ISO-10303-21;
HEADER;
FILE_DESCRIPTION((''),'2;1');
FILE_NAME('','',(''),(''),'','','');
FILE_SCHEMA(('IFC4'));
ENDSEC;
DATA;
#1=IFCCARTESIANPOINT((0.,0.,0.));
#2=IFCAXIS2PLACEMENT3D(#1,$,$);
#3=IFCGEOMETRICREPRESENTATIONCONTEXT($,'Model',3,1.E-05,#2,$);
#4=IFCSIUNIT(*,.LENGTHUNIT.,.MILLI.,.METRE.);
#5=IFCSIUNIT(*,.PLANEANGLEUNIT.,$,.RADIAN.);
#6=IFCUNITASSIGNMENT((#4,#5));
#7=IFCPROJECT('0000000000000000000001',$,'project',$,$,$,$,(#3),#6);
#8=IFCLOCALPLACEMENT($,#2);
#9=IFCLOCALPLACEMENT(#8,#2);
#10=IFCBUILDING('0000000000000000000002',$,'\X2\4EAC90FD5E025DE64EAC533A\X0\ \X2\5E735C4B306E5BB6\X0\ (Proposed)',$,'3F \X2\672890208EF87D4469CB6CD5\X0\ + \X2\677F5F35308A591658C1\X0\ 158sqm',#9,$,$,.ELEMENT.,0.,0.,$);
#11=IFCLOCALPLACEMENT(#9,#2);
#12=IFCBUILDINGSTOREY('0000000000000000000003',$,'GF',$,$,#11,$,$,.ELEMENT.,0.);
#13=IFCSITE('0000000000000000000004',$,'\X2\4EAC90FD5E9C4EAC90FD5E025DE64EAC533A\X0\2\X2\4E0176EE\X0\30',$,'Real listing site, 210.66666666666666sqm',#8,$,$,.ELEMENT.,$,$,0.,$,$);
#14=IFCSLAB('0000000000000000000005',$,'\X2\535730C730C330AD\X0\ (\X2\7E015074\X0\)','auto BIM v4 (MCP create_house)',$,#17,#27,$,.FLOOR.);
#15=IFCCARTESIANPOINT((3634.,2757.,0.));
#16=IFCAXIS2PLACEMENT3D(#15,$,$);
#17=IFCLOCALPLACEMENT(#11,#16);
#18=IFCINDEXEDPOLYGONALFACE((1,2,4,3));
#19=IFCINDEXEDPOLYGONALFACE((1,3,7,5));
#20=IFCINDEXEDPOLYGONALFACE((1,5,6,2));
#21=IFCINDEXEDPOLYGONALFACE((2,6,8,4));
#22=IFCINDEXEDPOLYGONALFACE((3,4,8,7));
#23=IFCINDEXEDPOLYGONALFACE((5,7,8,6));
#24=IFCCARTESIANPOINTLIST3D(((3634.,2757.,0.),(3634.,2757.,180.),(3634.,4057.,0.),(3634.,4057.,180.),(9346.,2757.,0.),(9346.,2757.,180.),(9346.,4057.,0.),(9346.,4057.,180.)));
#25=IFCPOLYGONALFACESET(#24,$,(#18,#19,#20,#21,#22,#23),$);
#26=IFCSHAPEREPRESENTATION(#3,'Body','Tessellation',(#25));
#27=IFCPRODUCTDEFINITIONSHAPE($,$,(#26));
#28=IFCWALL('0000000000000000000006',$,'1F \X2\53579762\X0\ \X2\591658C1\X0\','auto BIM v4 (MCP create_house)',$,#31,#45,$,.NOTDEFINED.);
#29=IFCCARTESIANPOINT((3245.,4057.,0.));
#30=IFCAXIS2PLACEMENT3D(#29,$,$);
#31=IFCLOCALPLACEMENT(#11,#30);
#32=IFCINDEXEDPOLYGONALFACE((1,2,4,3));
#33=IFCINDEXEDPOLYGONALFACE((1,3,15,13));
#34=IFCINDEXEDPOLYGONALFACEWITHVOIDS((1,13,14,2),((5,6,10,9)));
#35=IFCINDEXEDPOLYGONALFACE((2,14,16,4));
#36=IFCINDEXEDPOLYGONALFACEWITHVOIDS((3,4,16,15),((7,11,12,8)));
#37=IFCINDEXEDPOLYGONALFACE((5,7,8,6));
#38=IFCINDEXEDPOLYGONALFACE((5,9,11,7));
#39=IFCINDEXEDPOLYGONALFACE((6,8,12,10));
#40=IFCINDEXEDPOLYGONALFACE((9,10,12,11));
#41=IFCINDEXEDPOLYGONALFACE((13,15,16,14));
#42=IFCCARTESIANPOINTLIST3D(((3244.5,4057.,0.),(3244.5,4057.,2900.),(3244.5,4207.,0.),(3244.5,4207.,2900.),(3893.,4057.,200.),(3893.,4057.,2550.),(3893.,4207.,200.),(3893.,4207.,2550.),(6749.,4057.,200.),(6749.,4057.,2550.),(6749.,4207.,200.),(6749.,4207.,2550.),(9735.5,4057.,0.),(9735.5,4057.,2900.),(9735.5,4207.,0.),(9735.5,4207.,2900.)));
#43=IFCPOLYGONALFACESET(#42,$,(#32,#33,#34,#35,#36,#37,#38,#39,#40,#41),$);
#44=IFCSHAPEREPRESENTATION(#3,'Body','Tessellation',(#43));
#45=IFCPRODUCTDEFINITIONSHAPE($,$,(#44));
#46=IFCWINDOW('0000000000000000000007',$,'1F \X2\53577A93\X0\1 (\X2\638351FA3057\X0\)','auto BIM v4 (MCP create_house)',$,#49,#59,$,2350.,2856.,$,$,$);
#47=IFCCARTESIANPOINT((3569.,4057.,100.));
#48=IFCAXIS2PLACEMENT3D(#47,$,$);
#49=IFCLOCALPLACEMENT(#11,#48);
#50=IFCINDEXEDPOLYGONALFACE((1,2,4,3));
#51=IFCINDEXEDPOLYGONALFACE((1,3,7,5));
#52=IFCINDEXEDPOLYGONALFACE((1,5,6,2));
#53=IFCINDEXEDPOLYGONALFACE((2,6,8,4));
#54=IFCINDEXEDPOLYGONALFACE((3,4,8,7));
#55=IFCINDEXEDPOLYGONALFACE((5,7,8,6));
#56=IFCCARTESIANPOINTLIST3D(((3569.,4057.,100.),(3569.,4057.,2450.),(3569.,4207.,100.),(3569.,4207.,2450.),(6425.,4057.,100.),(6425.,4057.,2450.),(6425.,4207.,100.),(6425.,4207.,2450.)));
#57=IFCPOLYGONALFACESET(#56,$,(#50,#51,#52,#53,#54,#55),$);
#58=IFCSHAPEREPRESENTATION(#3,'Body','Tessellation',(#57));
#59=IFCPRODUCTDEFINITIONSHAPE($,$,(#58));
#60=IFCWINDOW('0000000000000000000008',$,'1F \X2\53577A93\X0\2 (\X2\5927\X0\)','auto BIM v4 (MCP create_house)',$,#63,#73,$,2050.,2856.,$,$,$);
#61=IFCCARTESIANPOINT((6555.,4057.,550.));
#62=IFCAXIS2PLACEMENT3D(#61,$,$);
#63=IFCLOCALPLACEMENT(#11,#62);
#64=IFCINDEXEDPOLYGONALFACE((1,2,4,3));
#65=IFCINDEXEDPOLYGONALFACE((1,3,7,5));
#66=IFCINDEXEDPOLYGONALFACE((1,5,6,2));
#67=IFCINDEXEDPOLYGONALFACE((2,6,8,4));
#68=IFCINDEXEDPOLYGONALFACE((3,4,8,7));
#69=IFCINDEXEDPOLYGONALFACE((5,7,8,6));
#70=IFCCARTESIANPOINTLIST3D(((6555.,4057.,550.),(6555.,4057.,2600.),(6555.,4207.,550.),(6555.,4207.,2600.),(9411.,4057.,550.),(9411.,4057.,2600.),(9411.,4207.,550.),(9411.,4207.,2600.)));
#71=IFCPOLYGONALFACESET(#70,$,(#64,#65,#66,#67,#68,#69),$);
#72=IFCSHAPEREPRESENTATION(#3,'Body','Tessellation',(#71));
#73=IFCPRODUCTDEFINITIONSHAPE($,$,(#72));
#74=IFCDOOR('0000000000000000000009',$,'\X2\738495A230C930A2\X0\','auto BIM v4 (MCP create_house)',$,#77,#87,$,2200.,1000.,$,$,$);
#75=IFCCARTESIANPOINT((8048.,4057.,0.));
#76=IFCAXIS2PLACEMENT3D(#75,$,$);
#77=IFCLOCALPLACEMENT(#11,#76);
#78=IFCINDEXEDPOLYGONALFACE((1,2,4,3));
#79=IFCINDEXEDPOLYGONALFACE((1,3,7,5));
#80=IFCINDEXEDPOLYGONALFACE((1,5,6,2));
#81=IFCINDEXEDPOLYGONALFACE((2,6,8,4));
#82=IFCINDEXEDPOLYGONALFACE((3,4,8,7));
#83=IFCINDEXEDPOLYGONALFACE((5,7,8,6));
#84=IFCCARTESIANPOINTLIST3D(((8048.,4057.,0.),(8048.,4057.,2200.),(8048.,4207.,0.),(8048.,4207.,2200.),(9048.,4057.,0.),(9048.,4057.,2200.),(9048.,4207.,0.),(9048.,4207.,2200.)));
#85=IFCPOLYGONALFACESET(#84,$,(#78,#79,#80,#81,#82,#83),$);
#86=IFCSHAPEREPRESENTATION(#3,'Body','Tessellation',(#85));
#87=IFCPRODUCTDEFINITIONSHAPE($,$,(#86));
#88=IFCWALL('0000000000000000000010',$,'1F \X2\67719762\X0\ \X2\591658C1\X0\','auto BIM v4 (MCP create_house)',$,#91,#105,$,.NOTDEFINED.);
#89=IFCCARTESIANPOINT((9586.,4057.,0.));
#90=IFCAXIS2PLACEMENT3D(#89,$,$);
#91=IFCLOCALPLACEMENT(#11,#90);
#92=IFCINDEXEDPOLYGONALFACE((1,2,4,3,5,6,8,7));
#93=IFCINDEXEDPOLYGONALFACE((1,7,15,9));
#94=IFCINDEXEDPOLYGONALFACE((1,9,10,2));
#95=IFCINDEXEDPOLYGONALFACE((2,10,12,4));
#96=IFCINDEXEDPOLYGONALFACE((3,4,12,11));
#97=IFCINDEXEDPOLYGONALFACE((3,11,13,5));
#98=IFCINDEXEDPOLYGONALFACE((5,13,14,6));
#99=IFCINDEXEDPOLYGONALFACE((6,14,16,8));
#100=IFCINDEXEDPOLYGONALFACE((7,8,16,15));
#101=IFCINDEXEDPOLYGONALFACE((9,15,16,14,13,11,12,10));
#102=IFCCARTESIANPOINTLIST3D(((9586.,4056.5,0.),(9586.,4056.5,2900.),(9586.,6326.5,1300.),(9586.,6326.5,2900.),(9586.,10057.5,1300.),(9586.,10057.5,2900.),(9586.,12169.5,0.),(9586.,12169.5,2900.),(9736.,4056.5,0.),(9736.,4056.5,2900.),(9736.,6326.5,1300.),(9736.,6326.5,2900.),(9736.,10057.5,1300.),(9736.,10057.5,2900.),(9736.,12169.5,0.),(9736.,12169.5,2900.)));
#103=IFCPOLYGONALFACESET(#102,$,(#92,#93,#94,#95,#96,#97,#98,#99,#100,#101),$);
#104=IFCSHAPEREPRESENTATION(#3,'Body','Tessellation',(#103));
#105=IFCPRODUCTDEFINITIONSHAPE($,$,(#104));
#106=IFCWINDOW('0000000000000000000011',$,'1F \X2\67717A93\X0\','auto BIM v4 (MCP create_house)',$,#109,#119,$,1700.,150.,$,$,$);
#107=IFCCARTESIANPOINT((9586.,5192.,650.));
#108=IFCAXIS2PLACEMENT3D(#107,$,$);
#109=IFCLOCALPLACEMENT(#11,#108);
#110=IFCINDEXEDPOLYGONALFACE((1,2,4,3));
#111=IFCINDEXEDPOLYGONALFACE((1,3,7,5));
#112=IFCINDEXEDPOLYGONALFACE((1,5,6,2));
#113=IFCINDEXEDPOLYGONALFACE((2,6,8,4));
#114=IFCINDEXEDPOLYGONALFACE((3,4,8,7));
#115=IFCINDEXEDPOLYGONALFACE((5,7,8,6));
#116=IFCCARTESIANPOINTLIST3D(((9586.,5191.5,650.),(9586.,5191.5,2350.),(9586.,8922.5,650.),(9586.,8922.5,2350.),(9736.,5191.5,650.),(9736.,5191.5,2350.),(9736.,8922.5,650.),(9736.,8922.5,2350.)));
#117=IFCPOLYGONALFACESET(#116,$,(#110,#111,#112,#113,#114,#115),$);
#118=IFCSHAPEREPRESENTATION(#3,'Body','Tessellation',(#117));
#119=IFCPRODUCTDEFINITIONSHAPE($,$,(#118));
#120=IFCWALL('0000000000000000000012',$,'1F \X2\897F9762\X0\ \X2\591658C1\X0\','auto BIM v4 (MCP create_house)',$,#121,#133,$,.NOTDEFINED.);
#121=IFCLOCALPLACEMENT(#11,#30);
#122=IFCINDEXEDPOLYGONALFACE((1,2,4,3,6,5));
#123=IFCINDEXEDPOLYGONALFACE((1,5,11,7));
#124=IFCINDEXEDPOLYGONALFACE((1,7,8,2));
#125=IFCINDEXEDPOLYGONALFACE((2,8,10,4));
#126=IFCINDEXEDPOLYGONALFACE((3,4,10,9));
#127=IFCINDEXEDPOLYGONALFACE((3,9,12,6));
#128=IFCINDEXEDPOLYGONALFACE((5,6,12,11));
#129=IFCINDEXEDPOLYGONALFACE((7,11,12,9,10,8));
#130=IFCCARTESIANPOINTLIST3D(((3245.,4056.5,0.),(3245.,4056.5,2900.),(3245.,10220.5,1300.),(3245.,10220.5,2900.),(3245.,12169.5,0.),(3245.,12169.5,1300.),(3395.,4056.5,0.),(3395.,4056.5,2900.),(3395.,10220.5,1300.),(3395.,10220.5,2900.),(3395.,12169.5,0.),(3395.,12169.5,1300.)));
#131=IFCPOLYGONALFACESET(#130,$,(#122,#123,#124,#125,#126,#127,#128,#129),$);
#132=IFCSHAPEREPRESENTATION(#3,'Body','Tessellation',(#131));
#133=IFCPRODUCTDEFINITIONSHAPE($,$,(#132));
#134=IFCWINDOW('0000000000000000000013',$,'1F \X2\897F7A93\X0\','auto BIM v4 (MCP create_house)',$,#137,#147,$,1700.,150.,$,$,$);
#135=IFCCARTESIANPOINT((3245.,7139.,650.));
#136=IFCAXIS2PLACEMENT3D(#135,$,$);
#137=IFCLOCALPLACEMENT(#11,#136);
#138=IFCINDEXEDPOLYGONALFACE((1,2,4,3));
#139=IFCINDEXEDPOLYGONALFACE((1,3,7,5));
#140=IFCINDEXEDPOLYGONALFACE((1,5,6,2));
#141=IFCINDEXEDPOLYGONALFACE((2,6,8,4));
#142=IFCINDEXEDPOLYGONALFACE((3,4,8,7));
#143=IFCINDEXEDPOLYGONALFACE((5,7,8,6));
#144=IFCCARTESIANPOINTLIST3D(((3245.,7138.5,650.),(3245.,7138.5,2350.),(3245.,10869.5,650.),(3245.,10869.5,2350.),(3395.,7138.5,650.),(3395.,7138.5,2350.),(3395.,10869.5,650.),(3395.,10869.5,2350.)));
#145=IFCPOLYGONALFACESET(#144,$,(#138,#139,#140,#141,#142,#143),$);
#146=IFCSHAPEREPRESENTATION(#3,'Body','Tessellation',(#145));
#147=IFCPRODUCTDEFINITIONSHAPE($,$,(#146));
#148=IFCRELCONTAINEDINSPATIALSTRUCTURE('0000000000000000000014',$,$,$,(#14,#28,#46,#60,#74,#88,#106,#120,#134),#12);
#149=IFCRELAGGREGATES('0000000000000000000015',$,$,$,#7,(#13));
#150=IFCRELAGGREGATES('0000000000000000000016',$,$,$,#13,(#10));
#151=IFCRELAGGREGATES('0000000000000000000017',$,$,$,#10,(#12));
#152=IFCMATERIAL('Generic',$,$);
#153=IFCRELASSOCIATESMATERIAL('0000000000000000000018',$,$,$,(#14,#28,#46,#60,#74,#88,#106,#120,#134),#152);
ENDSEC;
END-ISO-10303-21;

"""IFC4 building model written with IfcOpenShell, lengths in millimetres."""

from ifc_helpers import new_model, si_unit, frame, frame_2d, origin, place, context, project, spatial, rectangle, extrude, material, element, fill, save


model = new_model("IFC4")

# Units and contexts
model_context = context("Model", 3, precision=1e-05, world=origin())
ifc_project = project(units=[si_unit("LENGTHUNIT", "METRE", prefix="MILLI"), si_unit("PLANEANGLEUNIT", "RADIAN")], contexts=[model_context])

# Site, building, storey
site_placement = place(None, origin())
site = spatial("IfcSite", under=ifc_project, at=site_placement, Name="京都府京都市左京区2丁目30", ObjectType="Real listing site, 210.66666666666666sqm", CompositionType="ELEMENT", RefElevation=0.0)
building_placement = place(site_placement, origin())
building = spatial("IfcBuilding", under=site, at=building_placement, Name="京都市左京区 平屋の家 (Proposed)", ObjectType="3F 木造軸組構法 + 板張り外壁 158sqm", CompositionType="ELEMENT", ElevationOfRefHeight=0.0, ElevationOfTerrain=0.0)
storey_placement = place(building_placement, origin())
storey = spatial("IfcBuildingStorey", under=building, at=storey_placement, Name="GF", CompositionType="ELEMENT", Elevation=0.0)

# Slab
ifc_material = material(Name="Generic")
slab_1_placement = place(storey_placement, frame((3634.0, 2757.0, 0.0)))
element("IfcSlab", 1, at=slab_1_placement, inside=storey, material=ifc_material, Name="南デッキ (縁側)", Description="auto BIM v4 (MCP create_house)", PredefinedType="FLOOR", context=model_context, shape_type="SweptSolid", body=[
    extrude(rectangle(XDim=5712.0, YDim=1300.0, at=frame_2d((2856.0, 650.0))), frame((3634.0, 2757.0, 0.0)), (0.0, 0.0, 1.0), 180.0),
])

# Wall, openings, windows, door
wall_1_placement = place(storey_placement, frame((3245.0, 4057.0, 0.0)))
wall_1 = element("IfcWall", 2, at=wall_1_placement, inside=storey, material=ifc_material, Name="1F 南面 外壁", Description="auto BIM v4 (MCP create_house)", PredefinedType="NOTDEFINED", context=model_context, shape_type="SweptSolid", body=[
    extrude(rectangle(XDim=6491.0, YDim=150.0, at=frame_2d((3245.0, 75.0))), frame((3245.0, 4057.0, 0.0)), (0.0, 0.0, 1.0), 2900.0),
])
opening_1_placement = place(storey_placement, frame((3569.0, 4057.0, 100.0)))
opening_1 = element("IfcOpeningElement", 3, at=opening_1_placement, cuts=wall_1, PredefinedType="NOTDEFINED", context=model_context, shape_type="SweptSolid", body=[
    extrude(rectangle(XDim=2856.0, YDim=150.0, at=frame_2d((1428.0, 75.0))), frame((3569.0, 4057.0, 100.0)), (0.0, 0.0, 1.0), 2350.0),
])
opening_2_placement = place(storey_placement, frame((6555.0, 4057.0, 550.0)))
opening_2 = element("IfcOpeningElement", 4, at=opening_2_placement, cuts=wall_1, PredefinedType="NOTDEFINED", context=model_context, shape_type="SweptSolid", body=[
    extrude(rectangle(XDim=2856.0, YDim=150.0, at=frame_2d((1428.0, 75.0))), frame((6555.0, 4057.0, 550.0)), (0.0, 0.0, 1.0), 2050.0),
])
opening_3_placement = place(storey_placement, frame((8048.0, 4057.0, 0.0)))
opening_3 = element("IfcOpeningElement", 5, at=opening_3_placement, cuts=wall_1, PredefinedType="NOTDEFINED", context=model_context, shape_type="SweptSolid", body=[
    extrude(rectangle(XDim=1000.0, YDim=150.0, at=frame_2d((500.0, 75.0))), frame((8048.0, 4057.0, 0.0)), (0.0, 0.0, 1.0), 2200.0),
])
window_1_placement = place(storey_placement, frame((3569.0, 4057.0, 100.0)))
window_1 = element("IfcWindow", 6, at=window_1_placement, inside=storey, material=ifc_material, Name="1F 南窓1 (掃出し)", Description="auto BIM v4 (MCP create_house)", OverallHeight=2350.0, OverallWidth=2856.0, context=model_context, shape_type="SweptSolid", body=[
    extrude(rectangle(XDim=2856.0, YDim=150.0, at=frame_2d((1428.0, 75.0))), frame((3569.0, 4057.0, 100.0)), (0.0, 0.0, 1.0), 2350.0),
])
fill(opening_1, window_1)
window_2_placement = place(storey_placement, frame((6555.0, 4057.0, 550.0)))
window_2 = element("IfcWindow", 7, at=window_2_placement, inside=storey, material=ifc_material, Name="1F 南窓2 (大)", Description="auto BIM v4 (MCP create_house)", OverallHeight=2050.0, OverallWidth=2856.0, context=model_context, shape_type="SweptSolid", body=[
    extrude(rectangle(XDim=2856.0, YDim=150.0, at=frame_2d((1428.0, 75.0))), frame((6555.0, 4057.0, 550.0)), (0.0, 0.0, 1.0), 2050.0),
])
fill(opening_2, window_2)
door_placement = place(storey_placement, frame((8048.0, 4057.0, 0.0)))
door = element("IfcDoor", 8, at=door_placement, inside=storey, material=ifc_material, Name="玄関ドア", Description="auto BIM v4 (MCP create_house)", OverallHeight=2200.0, OverallWidth=1000.0, context=model_context, shape_type="SweptSolid", body=[
    extrude(rectangle(XDim=1000.0, YDim=150.0, at=frame_2d((500.0, 75.0))), frame((8048.0, 4057.0, 0.0)), (0.0, 0.0, 1.0), 2200.0),
])
fill(opening_3, door)

# Walls, openings, windows
wall_2_placement = place(storey_placement, frame((9586.0, 4057.0, 0.0)))
wall_2 = element("IfcWall", 9, at=wall_2_placement, inside=storey, material=ifc_material, Name="1F 東面 外壁", Description="auto BIM v4 (MCP create_house)", PredefinedType="NOTDEFINED", context=model_context, shape_type="SweptSolid", body=[
    extrude(rectangle(XDim=150.0, YDim=8113.0, at=frame_2d((75.0, 4056.0))), frame((9586.0, 4057.0, 0.0)), (0.0, 0.0, 1.0), 2900.0),
])
opening_4_placement = place(storey_placement, frame((9586.0, 5192.0, 650.0)))
opening_4 = element("IfcOpeningElement", 10, at=opening_4_placement, cuts=wall_2, PredefinedType="NOTDEFINED", context=model_context, shape_type="SweptSolid", body=[
    extrude(rectangle(XDim=150.0, YDim=3731.0, at=frame_2d((75.0, 1865.0))), frame((9586.0, 5192.0, 650.0)), (0.0, 0.0, 1.0), 1700.0),
])
window_3_placement = place(storey_placement, frame((9586.0, 5192.0, 650.0)))
window_3 = element("IfcWindow", 11, at=window_3_placement, inside=storey, material=ifc_material, Name="1F 東窓", Description="auto BIM v4 (MCP create_house)", OverallHeight=1700.0, OverallWidth=150.0, context=model_context, shape_type="SweptSolid", body=[
    extrude(rectangle(XDim=150.0, YDim=3731.0, at=frame_2d((75.0, 1865.0))), frame((9586.0, 5192.0, 650.0)), (0.0, 0.0, 1.0), 1700.0),
])
fill(opening_4, window_3)
wall_3_placement = place(storey_placement, frame((3245.0, 4057.0, 0.0)))
wall_3 = element("IfcWall", 12, at=wall_3_placement, inside=storey, material=ifc_material, Name="1F 西面 外壁", Description="auto BIM v4 (MCP create_house)", PredefinedType="NOTDEFINED", context=model_context, shape_type="SweptSolid", body=[
    extrude(rectangle(XDim=150.0, YDim=8113.0, at=frame_2d((75.0, 4056.0))), frame((3245.0, 4057.0, 0.0)), (0.0, 0.0, 1.0), 2900.0),
])
opening_5_placement = place(storey_placement, frame((3245.0, 7139.0, 650.0)))
opening_5 = element("IfcOpeningElement", 13, at=opening_5_placement, cuts=wall_3, PredefinedType="NOTDEFINED", context=model_context, shape_type="SweptSolid", body=[
    extrude(rectangle(XDim=150.0, YDim=3731.0, at=frame_2d((75.0, 1865.0))), frame((3245.0, 7139.0, 650.0)), (0.0, 0.0, 1.0), 1700.0),
])
window_4_placement = place(storey_placement, frame((3245.0, 7139.0, 650.0)))
window_4 = element("IfcWindow", 14, at=window_4_placement, inside=storey, material=ifc_material, Name="1F 西窓", Description="auto BIM v4 (MCP create_house)", OverallHeight=1700.0, OverallWidth=150.0, context=model_context, shape_type="SweptSolid", body=[
    extrude(rectangle(XDim=150.0, YDim=3731.0, at=frame_2d((75.0, 1865.0))), frame((3245.0, 7139.0, 650.0)), (0.0, 0.0, 1.0), 1700.0),
])
fill(opening_5, window_4)

save(model, "model.ifc")
